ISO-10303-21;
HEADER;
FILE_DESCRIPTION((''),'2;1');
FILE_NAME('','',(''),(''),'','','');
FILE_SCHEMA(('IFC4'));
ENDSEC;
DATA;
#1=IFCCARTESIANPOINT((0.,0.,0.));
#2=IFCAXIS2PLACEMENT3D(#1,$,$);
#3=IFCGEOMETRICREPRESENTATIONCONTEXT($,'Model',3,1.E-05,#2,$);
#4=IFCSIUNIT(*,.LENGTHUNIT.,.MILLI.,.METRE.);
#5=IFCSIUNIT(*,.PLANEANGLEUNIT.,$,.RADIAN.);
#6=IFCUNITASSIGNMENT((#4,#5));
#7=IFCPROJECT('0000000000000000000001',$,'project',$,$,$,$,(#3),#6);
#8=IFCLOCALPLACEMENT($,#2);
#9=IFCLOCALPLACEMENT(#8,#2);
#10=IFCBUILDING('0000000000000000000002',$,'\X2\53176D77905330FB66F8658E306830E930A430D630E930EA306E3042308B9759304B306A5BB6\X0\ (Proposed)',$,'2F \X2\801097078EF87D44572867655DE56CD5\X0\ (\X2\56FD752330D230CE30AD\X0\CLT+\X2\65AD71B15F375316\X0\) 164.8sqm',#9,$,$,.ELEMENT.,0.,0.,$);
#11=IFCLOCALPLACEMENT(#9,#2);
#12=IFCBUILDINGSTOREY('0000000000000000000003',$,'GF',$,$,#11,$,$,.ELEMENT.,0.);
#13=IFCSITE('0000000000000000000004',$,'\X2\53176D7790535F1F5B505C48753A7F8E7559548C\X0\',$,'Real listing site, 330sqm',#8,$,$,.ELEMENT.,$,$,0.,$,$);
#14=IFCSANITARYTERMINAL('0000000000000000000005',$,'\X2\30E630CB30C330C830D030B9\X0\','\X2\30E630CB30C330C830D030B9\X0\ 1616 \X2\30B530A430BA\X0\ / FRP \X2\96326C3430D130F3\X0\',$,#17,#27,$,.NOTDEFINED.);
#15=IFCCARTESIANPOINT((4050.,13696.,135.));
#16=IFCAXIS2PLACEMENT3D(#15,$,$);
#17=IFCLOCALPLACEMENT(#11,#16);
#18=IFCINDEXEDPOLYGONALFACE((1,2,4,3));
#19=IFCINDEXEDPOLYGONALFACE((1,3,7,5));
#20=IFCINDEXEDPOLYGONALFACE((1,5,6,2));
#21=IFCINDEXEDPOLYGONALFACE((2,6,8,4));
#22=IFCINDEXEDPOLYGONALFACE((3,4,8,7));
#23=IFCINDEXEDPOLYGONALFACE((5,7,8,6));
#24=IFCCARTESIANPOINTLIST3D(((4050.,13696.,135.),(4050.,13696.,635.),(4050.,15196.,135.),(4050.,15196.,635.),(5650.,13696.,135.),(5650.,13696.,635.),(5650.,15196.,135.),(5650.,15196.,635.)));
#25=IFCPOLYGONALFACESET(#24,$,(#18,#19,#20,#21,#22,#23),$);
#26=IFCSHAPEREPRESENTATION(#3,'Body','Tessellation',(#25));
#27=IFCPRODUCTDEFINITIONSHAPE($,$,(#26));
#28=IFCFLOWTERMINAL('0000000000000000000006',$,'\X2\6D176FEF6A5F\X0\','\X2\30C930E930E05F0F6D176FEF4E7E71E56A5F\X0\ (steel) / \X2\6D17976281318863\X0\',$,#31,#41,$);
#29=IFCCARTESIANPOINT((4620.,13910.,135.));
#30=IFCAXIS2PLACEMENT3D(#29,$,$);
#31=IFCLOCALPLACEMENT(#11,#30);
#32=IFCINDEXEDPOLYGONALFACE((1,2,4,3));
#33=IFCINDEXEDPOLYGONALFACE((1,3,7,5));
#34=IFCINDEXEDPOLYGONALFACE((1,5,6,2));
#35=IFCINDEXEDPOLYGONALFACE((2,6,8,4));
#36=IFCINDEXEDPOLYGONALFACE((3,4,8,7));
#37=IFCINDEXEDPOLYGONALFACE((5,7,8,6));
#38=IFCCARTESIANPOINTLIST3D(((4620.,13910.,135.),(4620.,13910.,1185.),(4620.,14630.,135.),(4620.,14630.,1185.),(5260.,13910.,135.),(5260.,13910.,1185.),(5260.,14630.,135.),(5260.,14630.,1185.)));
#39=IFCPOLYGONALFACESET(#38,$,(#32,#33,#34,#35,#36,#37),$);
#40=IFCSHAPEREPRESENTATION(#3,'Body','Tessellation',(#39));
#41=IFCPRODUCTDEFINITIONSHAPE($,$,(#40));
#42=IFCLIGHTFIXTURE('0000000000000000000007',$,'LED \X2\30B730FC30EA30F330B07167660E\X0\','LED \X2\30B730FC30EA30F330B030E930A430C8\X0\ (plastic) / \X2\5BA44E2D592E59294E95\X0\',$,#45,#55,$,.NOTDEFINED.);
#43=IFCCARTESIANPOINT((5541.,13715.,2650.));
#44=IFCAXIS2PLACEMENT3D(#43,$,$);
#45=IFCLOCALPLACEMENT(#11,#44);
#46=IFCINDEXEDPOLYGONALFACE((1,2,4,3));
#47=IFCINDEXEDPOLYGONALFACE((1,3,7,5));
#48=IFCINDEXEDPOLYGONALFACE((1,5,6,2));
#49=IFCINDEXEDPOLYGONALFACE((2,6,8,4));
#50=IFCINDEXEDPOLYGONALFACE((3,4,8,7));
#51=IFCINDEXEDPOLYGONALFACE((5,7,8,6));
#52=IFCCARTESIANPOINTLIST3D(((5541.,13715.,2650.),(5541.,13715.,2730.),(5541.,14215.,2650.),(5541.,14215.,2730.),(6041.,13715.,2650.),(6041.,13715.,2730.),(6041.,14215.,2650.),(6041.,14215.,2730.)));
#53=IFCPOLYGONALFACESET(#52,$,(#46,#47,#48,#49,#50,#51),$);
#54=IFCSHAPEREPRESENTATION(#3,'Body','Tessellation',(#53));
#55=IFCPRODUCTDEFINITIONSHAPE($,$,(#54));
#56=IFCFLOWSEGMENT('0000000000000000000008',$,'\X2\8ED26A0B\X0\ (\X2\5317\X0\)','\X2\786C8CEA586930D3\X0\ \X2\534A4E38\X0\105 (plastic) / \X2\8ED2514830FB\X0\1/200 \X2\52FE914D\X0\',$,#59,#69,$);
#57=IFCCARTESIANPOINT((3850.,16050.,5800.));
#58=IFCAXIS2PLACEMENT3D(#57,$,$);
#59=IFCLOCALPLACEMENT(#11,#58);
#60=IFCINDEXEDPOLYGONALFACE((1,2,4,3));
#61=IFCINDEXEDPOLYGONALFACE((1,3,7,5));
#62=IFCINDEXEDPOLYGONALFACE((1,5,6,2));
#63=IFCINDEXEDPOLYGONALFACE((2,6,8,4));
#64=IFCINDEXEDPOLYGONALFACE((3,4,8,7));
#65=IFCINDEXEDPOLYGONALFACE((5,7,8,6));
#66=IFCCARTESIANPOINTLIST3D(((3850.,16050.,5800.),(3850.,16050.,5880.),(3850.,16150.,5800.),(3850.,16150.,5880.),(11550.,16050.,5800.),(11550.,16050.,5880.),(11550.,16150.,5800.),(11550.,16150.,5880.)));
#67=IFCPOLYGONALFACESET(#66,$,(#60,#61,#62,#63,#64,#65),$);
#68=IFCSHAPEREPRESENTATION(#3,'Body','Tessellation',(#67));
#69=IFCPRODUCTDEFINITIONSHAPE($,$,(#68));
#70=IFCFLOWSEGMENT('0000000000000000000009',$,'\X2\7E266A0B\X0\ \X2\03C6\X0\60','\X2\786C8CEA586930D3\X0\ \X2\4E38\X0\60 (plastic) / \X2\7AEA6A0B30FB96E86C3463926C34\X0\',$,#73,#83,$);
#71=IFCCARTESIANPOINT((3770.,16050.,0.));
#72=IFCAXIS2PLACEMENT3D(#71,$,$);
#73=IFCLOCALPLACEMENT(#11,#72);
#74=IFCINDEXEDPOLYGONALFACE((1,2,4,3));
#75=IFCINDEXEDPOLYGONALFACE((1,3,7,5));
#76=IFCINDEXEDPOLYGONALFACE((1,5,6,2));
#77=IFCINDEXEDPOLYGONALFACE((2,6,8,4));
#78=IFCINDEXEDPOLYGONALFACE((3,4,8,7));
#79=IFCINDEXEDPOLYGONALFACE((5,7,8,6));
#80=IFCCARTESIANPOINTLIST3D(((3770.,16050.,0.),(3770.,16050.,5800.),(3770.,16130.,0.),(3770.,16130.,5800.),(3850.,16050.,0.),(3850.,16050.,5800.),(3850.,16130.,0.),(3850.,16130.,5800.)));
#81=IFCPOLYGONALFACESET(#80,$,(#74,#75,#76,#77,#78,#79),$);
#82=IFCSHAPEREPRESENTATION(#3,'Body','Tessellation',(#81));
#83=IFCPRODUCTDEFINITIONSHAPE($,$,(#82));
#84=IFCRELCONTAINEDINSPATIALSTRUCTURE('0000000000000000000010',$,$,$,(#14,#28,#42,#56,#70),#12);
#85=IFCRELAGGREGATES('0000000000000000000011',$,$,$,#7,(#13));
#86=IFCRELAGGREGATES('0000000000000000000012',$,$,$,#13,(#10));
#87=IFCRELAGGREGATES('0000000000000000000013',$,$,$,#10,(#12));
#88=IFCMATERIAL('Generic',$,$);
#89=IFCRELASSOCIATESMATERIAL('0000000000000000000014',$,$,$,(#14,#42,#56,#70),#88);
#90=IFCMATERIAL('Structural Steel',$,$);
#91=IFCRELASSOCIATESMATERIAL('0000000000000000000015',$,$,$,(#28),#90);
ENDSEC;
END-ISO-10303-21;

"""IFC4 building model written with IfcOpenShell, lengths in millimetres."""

from ifc_helpers import new_model, si_unit, frame, frame_2d, origin, place, context, project, spatial, rectangle, extrude, material, element, save


model = new_model("IFC4")

# Units and contexts
model_context = context("Model", 3, precision=1e-05, world=origin())
ifc_project = project(units=[si_unit("LENGTHUNIT", "METRE", prefix="MILLI"), si_unit("PLANEANGLEUNIT", "RADIAN")], contexts=[model_context])

# Site, building, storey
site_placement = place(None, origin())
site = spatial("IfcSite", under=ifc_project, at=site_placement, Name="北海道弟子屈町美留和", ObjectType="Real listing site, 330sqm", CompositionType="ELEMENT", RefElevation=0.0)
building_placement = place(site_placement, origin())
building = spatial("IfcBuilding", under=site, at=building_placement, Name="北海道・書斎とライブラリのある静かな家 (Proposed)", ObjectType="2F 耐震軸組在来工法 (国産ヒノキCLT+断熱強化) 164.8sqm", CompositionType="ELEMENT", ElevationOfRefHeight=0.0, ElevationOfTerrain=0.0)
storey_placement = place(building_placement, origin())
storey = spatial("IfcBuildingStorey", under=building, at=storey_placement, Name="GF", CompositionType="ELEMENT", Elevation=0.0)

# Sanitary terminal
ifc_material_1 = material(Name="Generic")
sanitary_terminal_placement = place(storey_placement, frame((4050.0, 13696.0, 135.0)))
element("IfcSanitaryTerminal", 1, at=sanitary_terminal_placement, inside=storey, material=ifc_material_1, Name="ユニットバス", Description="ユニットバス 1616 サイズ / FRP 防水パン", PredefinedType="NOTDEFINED", context=model_context, shape_type="SweptSolid", body=[
    extrude(rectangle(XDim=1600.0, YDim=1500.0, at=frame_2d((800.0, 750.0))), frame((4050.0, 13696.0, 135.0)), (0.0, 0.0, 1.0), 500.0),
])

# Flow terminal
ifc_material_2 = material(Name="Structural Steel")
flow_terminal_placement = place(storey_placement, frame((4620.0, 13910.0, 135.0)))
element("IfcFlowTerminal", 2, at=flow_terminal_placement, inside=storey, material=ifc_material_2, Name="洗濯機", Description="ドラム式洗濯乾燥機 (steel) / 洗面脱衣", context=model_context, shape_type="SweptSolid", body=[
    extrude(rectangle(XDim=640.0, YDim=720.0, at=frame_2d((320.0, 360.0))), frame((4620.0, 13910.0, 135.0)), (0.0, 0.0, 1.0), 1050.0),
])

# Light fixture
light_fixture_placement = place(storey_placement, frame((5541.0, 13715.0, 2650.0)))
element("IfcLightFixture", 3, at=light_fixture_placement, inside=storey, material=ifc_material_1, Name="LED シーリング照明", Description="LED シーリングライト (plastic) / 室中央天井", PredefinedType="NOTDEFINED", context=model_context, shape_type="SweptSolid", body=[
    extrude(rectangle(XDim=500.0, YDim=500.0, at=frame_2d((250.0, 250.0))), frame((5541.0, 13715.0, 2650.0)), (0.0, 0.0, 1.0), 80.0),
])

# Flow segments
flow_segment_1_placement = place(storey_placement, frame((3850.0, 16050.0, 5800.0)))
element("IfcFlowSegment", 4, at=flow_segment_1_placement, inside=storey, material=ifc_material_1, Name="軒樋 (北)", Description="硬質塩ビ 半丸105 (plastic) / 軒先・1/200 勾配", context=model_context, shape_type="SweptSolid", body=[
    extrude(rectangle(XDim=7700.0, YDim=100.0, at=frame_2d((3850.0, 50.0))), frame((3850.0, 16050.0, 5800.0)), (0.0, 0.0, 1.0), 80.0),
])
flow_segment_2_placement = place(storey_placement, frame((3770.0, 16050.0, 0.0)))
element("IfcFlowSegment", 5, at=flow_segment_2_placement, inside=storey, material=ifc_material_1, Name="縦樋 φ60", Description="硬質塩ビ 丸60 (plastic) / 竪樋・雨水排水", context=model_context, shape_type="SweptSolid", body=[
    extrude(rectangle(XDim=80.0, YDim=80.0, at=frame_2d((40.0, 40.0))), frame((3770.0, 16050.0, 0.0)), (0.0, 0.0, 1.0), 5800.0),
])

save(model, "model.ifc")
